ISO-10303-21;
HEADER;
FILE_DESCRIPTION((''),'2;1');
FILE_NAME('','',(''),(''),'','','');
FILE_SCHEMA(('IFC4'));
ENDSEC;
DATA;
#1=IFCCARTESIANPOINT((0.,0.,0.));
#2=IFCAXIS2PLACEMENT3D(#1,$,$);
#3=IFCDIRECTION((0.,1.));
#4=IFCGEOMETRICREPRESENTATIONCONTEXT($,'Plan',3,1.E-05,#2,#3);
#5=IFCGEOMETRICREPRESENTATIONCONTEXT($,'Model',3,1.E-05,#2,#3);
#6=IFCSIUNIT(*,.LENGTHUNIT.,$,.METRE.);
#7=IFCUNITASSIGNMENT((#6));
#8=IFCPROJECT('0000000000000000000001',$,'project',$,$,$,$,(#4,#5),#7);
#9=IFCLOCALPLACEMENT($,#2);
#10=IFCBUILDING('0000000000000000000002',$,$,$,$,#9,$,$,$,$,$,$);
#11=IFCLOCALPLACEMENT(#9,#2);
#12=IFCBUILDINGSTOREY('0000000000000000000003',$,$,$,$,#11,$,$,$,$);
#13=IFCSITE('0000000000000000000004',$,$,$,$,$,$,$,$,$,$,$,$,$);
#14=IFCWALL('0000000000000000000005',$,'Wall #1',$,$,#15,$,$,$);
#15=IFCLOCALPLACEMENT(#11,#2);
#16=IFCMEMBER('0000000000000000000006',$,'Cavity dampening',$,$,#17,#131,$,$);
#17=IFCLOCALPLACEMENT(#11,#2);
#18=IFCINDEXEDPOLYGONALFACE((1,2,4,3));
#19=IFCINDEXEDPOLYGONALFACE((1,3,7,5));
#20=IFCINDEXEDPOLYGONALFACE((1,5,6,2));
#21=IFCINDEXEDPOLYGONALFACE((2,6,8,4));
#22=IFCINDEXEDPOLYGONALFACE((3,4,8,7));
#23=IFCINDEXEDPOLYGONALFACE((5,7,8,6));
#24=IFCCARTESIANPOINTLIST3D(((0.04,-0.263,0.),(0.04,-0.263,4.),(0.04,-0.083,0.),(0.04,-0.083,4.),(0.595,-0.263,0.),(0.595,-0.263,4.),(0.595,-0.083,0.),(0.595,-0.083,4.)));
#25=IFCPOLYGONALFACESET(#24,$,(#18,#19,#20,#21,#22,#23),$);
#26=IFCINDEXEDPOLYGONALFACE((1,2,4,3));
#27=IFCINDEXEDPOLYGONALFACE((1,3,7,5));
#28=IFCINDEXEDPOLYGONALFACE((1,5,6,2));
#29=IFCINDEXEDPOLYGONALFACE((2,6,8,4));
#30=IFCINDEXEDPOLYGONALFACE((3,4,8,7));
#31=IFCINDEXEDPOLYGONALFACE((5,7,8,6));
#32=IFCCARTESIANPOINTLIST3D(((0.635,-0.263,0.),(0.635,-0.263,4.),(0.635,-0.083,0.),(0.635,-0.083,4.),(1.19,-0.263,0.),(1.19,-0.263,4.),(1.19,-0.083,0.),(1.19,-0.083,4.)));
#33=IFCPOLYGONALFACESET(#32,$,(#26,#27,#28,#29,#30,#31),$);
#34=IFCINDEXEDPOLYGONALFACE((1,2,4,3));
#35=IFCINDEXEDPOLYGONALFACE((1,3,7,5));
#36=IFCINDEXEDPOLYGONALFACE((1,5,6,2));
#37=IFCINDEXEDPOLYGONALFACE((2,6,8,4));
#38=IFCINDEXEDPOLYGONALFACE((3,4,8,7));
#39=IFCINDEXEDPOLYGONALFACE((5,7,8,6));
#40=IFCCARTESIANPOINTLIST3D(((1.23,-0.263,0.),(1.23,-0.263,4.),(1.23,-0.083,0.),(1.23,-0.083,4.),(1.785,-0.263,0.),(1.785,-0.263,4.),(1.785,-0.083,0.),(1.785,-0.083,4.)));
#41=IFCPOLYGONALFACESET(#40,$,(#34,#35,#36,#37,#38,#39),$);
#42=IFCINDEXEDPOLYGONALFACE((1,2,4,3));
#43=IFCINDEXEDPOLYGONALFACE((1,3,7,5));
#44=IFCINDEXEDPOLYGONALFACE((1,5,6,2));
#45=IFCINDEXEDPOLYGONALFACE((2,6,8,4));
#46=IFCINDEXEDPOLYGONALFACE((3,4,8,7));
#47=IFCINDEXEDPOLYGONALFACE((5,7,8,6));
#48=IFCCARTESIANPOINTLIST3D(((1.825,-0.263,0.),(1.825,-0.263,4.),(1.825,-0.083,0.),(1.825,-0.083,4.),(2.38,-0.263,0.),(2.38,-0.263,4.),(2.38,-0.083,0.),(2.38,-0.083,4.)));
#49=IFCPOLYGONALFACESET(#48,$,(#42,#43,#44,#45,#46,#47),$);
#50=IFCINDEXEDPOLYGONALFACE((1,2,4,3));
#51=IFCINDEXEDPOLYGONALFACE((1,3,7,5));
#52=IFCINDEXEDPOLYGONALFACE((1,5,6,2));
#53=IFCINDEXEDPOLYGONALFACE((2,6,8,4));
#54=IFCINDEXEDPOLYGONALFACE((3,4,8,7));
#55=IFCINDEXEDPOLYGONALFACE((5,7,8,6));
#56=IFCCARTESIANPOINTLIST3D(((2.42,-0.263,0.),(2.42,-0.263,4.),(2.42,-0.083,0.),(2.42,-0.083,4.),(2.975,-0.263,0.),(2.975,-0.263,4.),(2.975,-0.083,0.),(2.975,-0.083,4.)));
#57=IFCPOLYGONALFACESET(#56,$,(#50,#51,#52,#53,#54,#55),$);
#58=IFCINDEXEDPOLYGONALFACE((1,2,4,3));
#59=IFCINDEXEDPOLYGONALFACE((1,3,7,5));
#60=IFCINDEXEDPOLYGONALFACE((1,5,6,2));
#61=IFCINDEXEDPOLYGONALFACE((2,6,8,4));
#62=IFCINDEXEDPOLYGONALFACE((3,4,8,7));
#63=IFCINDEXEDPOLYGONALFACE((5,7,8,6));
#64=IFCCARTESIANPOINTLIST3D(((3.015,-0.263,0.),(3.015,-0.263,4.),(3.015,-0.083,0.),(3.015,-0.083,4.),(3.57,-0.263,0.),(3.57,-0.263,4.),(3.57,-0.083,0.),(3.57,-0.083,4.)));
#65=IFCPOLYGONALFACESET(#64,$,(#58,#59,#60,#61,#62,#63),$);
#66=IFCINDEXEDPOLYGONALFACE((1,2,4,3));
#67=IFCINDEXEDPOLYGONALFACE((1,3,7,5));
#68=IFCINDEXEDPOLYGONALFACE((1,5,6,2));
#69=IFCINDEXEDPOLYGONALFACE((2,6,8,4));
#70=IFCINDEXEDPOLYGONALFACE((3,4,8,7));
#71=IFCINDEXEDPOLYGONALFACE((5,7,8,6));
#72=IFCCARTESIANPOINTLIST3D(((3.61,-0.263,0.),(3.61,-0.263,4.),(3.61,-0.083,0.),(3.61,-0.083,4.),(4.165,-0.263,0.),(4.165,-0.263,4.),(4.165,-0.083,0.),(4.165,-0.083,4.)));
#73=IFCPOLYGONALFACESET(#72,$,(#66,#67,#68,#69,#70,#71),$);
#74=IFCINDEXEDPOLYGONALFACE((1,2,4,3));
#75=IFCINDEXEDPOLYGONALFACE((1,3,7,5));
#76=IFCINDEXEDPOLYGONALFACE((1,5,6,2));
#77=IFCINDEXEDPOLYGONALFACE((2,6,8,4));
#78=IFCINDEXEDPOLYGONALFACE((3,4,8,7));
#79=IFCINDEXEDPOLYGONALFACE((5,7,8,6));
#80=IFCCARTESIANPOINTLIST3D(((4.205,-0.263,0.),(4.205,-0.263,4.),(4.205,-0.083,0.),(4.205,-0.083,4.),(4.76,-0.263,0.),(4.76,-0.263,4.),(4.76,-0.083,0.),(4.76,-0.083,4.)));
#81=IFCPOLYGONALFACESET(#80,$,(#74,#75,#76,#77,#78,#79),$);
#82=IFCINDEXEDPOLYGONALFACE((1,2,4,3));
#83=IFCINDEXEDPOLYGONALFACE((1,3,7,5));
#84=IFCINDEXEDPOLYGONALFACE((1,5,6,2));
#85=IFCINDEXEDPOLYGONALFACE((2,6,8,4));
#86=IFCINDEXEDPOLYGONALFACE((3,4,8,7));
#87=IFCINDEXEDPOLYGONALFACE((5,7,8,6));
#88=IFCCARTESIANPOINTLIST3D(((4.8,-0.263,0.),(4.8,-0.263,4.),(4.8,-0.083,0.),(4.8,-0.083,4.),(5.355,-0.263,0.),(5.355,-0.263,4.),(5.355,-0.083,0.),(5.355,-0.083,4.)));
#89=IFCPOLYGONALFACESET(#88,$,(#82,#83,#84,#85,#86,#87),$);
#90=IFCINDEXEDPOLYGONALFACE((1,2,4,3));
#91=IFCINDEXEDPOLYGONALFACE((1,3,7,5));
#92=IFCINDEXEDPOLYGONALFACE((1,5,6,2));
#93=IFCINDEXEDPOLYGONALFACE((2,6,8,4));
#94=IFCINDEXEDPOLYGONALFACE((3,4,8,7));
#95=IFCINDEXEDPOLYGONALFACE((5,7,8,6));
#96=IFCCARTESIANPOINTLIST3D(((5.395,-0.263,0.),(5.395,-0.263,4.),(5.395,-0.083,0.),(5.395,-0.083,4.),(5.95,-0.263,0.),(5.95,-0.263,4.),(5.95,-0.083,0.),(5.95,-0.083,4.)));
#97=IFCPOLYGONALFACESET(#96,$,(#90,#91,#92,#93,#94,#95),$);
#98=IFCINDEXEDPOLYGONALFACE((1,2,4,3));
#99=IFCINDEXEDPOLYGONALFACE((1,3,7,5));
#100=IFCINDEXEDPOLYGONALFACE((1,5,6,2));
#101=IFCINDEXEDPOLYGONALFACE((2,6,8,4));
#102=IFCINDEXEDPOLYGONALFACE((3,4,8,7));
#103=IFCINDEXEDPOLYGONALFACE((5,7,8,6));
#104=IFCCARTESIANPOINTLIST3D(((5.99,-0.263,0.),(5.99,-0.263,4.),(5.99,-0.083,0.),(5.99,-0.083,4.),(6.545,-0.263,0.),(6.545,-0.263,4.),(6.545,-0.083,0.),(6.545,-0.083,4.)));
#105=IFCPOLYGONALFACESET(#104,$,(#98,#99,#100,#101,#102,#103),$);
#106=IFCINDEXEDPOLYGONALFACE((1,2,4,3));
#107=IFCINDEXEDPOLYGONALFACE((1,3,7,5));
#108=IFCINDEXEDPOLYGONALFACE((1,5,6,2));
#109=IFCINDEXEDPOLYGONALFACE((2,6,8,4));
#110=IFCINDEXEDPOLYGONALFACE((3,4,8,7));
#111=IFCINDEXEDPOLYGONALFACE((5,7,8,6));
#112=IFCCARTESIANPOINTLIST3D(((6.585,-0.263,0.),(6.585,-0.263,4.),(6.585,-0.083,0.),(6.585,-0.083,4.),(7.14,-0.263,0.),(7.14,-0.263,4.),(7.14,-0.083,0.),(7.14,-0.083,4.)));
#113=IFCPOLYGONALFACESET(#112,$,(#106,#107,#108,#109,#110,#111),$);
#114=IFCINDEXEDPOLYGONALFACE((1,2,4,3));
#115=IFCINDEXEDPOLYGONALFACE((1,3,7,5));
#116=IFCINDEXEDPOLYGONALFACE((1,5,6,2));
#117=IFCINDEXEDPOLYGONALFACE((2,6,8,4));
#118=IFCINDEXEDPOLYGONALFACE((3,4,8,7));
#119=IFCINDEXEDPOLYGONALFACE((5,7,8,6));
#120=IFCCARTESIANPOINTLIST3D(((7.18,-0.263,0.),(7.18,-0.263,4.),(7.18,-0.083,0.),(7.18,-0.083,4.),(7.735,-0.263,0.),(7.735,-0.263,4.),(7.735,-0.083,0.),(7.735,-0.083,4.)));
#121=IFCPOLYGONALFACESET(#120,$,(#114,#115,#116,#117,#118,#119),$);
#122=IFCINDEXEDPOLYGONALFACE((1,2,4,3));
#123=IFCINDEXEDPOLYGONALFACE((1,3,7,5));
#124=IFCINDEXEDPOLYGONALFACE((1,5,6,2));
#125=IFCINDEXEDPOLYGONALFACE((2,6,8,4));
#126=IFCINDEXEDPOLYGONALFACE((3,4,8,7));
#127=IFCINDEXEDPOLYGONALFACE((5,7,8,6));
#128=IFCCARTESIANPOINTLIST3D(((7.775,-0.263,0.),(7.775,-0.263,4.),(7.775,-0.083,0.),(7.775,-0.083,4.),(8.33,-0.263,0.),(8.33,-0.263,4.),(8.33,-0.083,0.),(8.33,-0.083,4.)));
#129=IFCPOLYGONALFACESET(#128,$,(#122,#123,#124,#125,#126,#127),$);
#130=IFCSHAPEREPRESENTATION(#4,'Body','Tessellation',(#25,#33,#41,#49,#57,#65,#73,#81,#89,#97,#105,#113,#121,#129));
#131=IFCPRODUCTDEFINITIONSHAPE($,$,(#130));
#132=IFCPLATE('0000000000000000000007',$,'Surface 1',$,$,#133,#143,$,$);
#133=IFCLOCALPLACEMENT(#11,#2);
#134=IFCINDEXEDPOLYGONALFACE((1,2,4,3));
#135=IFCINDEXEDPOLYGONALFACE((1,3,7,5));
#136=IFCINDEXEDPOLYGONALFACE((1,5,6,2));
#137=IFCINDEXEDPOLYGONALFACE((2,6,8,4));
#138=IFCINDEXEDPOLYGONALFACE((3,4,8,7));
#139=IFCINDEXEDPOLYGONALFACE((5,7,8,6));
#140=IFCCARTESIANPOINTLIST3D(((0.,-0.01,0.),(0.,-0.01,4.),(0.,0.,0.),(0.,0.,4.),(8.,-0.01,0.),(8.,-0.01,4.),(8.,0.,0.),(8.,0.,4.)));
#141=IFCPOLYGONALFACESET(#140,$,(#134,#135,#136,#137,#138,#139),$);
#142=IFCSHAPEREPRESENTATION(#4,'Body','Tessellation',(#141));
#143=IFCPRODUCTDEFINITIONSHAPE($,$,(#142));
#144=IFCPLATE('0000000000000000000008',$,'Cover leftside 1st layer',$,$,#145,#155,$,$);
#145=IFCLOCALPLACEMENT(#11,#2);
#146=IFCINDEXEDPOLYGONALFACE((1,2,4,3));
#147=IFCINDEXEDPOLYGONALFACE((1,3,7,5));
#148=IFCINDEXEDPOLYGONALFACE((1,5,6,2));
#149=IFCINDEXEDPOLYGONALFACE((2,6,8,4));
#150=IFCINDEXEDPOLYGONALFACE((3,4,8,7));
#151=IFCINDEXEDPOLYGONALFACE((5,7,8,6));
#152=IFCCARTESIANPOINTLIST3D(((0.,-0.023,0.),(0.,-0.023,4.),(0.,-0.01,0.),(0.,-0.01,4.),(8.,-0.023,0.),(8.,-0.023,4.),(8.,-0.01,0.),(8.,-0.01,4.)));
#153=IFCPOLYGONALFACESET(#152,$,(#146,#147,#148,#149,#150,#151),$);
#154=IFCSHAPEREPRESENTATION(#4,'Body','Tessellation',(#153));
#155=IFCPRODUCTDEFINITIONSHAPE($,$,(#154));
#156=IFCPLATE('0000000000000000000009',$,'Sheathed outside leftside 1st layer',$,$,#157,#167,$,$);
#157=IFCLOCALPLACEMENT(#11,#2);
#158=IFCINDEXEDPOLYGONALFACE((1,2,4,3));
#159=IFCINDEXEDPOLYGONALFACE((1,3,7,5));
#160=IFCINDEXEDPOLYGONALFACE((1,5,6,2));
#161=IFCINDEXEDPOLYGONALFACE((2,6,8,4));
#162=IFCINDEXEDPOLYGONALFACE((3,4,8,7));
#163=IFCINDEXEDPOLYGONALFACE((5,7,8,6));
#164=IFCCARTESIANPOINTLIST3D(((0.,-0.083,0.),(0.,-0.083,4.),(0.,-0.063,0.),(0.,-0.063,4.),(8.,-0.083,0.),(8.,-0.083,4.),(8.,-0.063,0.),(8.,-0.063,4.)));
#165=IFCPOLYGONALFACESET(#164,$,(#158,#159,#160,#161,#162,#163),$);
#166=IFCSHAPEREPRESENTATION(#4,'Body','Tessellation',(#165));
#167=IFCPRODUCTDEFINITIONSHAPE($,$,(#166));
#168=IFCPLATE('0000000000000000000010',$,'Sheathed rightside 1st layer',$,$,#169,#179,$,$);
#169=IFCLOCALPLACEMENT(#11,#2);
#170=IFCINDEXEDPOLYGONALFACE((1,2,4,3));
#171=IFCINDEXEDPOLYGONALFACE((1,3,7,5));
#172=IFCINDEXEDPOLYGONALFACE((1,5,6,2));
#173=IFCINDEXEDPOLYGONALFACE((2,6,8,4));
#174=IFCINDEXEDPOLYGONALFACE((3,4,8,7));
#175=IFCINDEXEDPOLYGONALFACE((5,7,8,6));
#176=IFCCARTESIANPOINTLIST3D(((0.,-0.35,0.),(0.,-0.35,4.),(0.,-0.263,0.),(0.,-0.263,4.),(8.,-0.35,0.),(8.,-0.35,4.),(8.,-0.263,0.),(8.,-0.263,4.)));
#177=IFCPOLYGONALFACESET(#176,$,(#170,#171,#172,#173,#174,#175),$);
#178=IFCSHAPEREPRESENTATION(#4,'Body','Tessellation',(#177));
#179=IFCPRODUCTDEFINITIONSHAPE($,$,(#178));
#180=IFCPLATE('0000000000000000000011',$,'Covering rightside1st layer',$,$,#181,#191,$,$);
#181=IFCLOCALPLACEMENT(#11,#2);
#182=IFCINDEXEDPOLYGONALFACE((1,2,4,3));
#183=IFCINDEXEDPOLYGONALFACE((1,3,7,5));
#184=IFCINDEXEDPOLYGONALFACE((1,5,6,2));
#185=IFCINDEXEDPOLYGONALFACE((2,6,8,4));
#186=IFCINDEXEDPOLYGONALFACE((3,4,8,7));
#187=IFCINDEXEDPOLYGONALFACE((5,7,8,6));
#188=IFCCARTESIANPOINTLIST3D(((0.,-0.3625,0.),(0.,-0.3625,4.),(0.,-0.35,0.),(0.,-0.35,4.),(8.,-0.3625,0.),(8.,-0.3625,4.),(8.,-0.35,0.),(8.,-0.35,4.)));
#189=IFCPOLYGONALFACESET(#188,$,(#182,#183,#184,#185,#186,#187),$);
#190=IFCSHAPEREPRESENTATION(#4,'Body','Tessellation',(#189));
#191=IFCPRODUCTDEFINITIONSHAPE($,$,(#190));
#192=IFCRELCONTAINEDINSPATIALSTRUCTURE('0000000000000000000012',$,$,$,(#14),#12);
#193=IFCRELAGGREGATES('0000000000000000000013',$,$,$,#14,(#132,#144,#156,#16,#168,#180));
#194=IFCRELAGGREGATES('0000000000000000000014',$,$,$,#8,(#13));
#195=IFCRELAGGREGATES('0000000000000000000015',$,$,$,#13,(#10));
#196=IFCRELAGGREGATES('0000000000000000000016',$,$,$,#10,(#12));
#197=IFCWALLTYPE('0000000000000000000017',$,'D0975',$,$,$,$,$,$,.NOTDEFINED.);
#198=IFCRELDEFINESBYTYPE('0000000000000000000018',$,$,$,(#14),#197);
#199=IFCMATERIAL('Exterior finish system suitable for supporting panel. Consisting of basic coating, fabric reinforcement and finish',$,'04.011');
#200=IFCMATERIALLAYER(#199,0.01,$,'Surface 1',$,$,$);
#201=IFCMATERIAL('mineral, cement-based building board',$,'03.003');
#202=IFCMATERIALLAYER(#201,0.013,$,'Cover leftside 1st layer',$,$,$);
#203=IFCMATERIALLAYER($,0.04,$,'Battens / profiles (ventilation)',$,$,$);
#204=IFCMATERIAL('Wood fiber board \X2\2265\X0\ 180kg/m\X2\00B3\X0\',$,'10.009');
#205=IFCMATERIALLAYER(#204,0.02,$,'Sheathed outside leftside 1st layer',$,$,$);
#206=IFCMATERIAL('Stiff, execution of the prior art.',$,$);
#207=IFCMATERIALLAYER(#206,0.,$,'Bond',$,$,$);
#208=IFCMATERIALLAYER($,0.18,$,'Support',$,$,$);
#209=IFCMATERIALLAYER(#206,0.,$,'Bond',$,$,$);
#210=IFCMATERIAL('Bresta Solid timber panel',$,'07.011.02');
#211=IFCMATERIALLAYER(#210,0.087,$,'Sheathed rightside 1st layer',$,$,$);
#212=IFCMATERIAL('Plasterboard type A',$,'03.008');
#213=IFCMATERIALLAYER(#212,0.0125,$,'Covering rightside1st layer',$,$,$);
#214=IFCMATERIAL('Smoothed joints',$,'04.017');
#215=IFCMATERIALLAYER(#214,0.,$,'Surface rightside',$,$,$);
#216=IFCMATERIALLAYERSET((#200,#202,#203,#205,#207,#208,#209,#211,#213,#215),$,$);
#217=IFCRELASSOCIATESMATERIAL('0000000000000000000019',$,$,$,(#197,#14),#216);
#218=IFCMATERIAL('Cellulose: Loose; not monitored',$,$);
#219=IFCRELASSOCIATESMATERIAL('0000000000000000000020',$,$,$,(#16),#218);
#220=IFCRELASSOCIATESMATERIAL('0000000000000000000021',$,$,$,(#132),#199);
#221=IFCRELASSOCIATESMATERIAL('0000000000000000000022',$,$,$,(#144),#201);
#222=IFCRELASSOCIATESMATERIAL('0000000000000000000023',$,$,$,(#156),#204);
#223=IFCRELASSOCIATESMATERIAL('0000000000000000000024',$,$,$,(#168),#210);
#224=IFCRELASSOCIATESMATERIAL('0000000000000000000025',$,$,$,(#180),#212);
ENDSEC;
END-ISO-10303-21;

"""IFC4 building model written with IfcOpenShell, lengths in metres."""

from ifc_helpers import new_model, si_unit, direction, frame, frame_2d, origin, origin_with_axes, place, context, project, spatial, rectangle, extrude, material, layer, layer_set, type_object, element, aggregate, save


model = new_model("IFC4")

# Units and contexts
plan_context = context("Plan", 3, precision=1e-05, world=origin(), true_north=direction((0.0, 1.0)))
model_context = context("Model", 3, precision=1e-05, world=origin(), true_north=direction((0.0, 1.0)))
ifc_project = project(units=[si_unit("LENGTHUNIT", "METRE")], contexts=[plan_context, model_context])

# Site, building, storey
site = spatial("IfcSite", under=ifc_project)
building_placement = place(None, origin())
building = spatial("IfcBuilding", under=site, at=building_placement)
storey_placement = place(building_placement, origin())
storey = spatial("IfcBuildingStorey", under=building, at=storey_placement)

# Wall, member, plates
ifc_material_1 = material(Name="Exterior finish system suitable for supporting panel. Consisting of basic coating, fabric reinforcement and finish", Category="04.011")
ifc_layer_1 = layer(ifc_material_1, 0.01, Name="Surface 1")
ifc_material_2 = material(Name="mineral, cement-based building board", Category="03.003")
ifc_layer_2 = layer(ifc_material_2, 0.013, Name="Cover leftside 1st layer")
ifc_layer_3 = layer(None, 0.04, Name="Battens / profiles (ventilation)")
ifc_material_3 = material(Name="Wood fiber board ≥ 180kg/m³", Category="10.009")
ifc_layer_4 = layer(ifc_material_3, 0.02, Name="Sheathed outside leftside 1st layer")
ifc_material_4 = material(Name="Stiff, execution of the prior art.")
ifc_layer_5 = layer(ifc_material_4, 0.0, Name="Bond")
ifc_layer_6 = layer(None, 0.18, Name="Support")
ifc_layer_7 = layer(ifc_material_4, 0.0, Name="Bond")
ifc_material_5 = material(Name="Bresta Solid timber panel", Category="07.011.02")
ifc_layer_8 = layer(ifc_material_5, 0.087, Name="Sheathed rightside 1st layer")
ifc_material_6 = material(Name="Plasterboard type A", Category="03.008")
ifc_layer_9 = layer(ifc_material_6, 0.0125, Name="Covering rightside1st layer")
ifc_material_7 = material(Name="Smoothed joints", Category="04.017")
ifc_layer_10 = layer(ifc_material_7, 0.0, Name="Surface rightside")
ifc_layer_set = layer_set([ifc_layer_1, ifc_layer_2, ifc_layer_3, ifc_layer_4, ifc_layer_5, ifc_layer_6, ifc_layer_7, ifc_layer_8, ifc_layer_9, ifc_layer_10])
wall_type = type_object("IfcWallType", Name="D0975", PredefinedType="NOTDEFINED", material=ifc_layer_set)
wall_placement = place(None, frame((0.0, 0.0, 0.0), z_axis=(0.0, -1.0, 0.0), x_axis=(1.0, 0.0, 0.0)))
wall = element("IfcWall", 1, at=wall_placement, inside=storey, type_object=wall_type, material=ifc_layer_set, Name="Wall #1")
ifc_material_8 = material(Name="Cellulose: Loose; not monitored")
member_1_placement = place(wall_placement, origin())
member_1 = element("IfcMember", 2, at=member_1_placement, material=ifc_material_8, Name="Cavity dampening", context=plan_context, shape_type="SweptSolid", body=[
    extrude(rectangle(XDim=0.555, YDim=0.18, at=frame_2d((0.2775, 0.09), x_axis=(1.0, 0.0))), frame((0.04, 4.0, 0.083), z_axis=(0.0, -1.0, 0.0), x_axis=(1.0, 0.0, 0.0)), (0.0, 0.0, 1.0), 4.0),
    extrude(rectangle(XDim=0.555, YDim=0.18, at=frame_2d((0.2775, 0.09), x_axis=(1.0, 0.0))), frame((0.635, 4.0, 0.083), z_axis=(0.0, -1.0, 0.0), x_axis=(1.0, 0.0, 0.0)), (0.0, 0.0, 1.0), 4.0),
    extrude(rectangle(XDim=0.555, YDim=0.18, at=frame_2d((0.2775, 0.09), x_axis=(1.0, 0.0))), frame((1.23, 4.0, 0.083), z_axis=(0.0, -1.0, 0.0), x_axis=(1.0, 0.0, 0.0)), (0.0, 0.0, 1.0), 4.0),
    extrude(rectangle(XDim=0.555, YDim=0.18, at=frame_2d((0.2775, 0.09), x_axis=(1.0, 0.0))), frame((1.825, 4.0, 0.083), z_axis=(0.0, -1.0, 0.0), x_axis=(1.0, 0.0, 0.0)), (0.0, 0.0, 1.0), 4.0),
    extrude(rectangle(XDim=0.555, YDim=0.18, at=frame_2d((0.2775, 0.09), x_axis=(1.0, 0.0))), frame((2.42, 4.0, 0.083), z_axis=(0.0, -1.0, 0.0), x_axis=(1.0, 0.0, 0.0)), (0.0, 0.0, 1.0), 4.0),
    extrude(rectangle(XDim=0.555, YDim=0.18, at=frame_2d((0.2775, 0.09), x_axis=(1.0, 0.0))), frame((3.015, 4.0, 0.083), z_axis=(0.0, -1.0, 0.0), x_axis=(1.0, 0.0, 0.0)), (0.0, 0.0, 1.0), 4.0),
    extrude(rectangle(XDim=0.555, YDim=0.18, at=frame_2d((0.2775, 0.09), x_axis=(1.0, 0.0))), frame((3.61, 4.0, 0.083), z_axis=(0.0, -1.0, 0.0), x_axis=(1.0, 0.0, 0.0)), (0.0, 0.0, 1.0), 4.0),
    extrude(rectangle(XDim=0.555, YDim=0.18, at=frame_2d((0.2775, 0.09), x_axis=(1.0, 0.0))), frame((4.205, 4.0, 0.083), z_axis=(0.0, -1.0, 0.0), x_axis=(1.0, 0.0, 0.0)), (0.0, 0.0, 1.0), 4.0),
    extrude(rectangle(XDim=0.555, YDim=0.18, at=frame_2d((0.2775, 0.09), x_axis=(1.0, 0.0))), frame((4.8, 4.0, 0.083), z_axis=(0.0, -1.0, 0.0), x_axis=(1.0, 0.0, 0.0)), (0.0, 0.0, 1.0), 4.0),
    extrude(rectangle(XDim=0.555, YDim=0.18, at=frame_2d((0.2775, 0.09), x_axis=(1.0, 0.0))), frame((5.395, 4.0, 0.083), z_axis=(0.0, -1.0, 0.0), x_axis=(1.0, 0.0, 0.0)), (0.0, 0.0, 1.0), 4.0),
    extrude(rectangle(XDim=0.555, YDim=0.18, at=frame_2d((0.2775, 0.09), x_axis=(1.0, 0.0))), frame((5.99, 4.0, 0.083), z_axis=(0.0, -1.0, 0.0), x_axis=(1.0, 0.0, 0.0)), (0.0, 0.0, 1.0), 4.0),
    extrude(rectangle(XDim=0.555, YDim=0.18, at=frame_2d((0.2775, 0.09), x_axis=(1.0, 0.0))), frame((6.585, 4.0, 0.083), z_axis=(0.0, -1.0, 0.0), x_axis=(1.0, 0.0, 0.0)), (0.0, 0.0, 1.0), 4.0),
    extrude(rectangle(XDim=0.555, YDim=0.18, at=frame_2d((0.2775, 0.09), x_axis=(1.0, 0.0))), frame((7.18, 4.0, 0.083), z_axis=(0.0, -1.0, 0.0), x_axis=(1.0, 0.0, 0.0)), (0.0, 0.0, 1.0), 4.0),
    extrude(rectangle(XDim=0.555, YDim=0.18, at=frame_2d((0.2775, 0.09), x_axis=(1.0, 0.0))), frame((7.775, 4.0, 0.083), z_axis=(0.0, -1.0, 0.0), x_axis=(1.0, 0.0, 0.0)), (0.0, 0.0, 1.0), 4.0),
])
plate_1_placement = place(wall_placement, origin())
plate_1 = element("IfcPlate", 3, at=plate_1_placement, material=ifc_material_1, Name="Surface 1", context=plan_context, shape_type="SweptSolid", body=[
    extrude(rectangle(XDim=8.0, YDim=4.0, at=frame_2d((4.0, 2.0), x_axis=(1.0, 0.0))), origin_with_axes(), (0.0, 0.0, 1.0), 0.01),
])
plate_2_placement = place(wall_placement, origin())
plate_2 = element("IfcPlate", 4, at=plate_2_placement, material=ifc_material_2, Name="Cover leftside 1st layer", context=plan_context, shape_type="SweptSolid", body=[
    extrude(rectangle(XDim=8.0, YDim=4.0, at=frame_2d((4.0, 2.0), x_axis=(1.0, 0.0))), frame((0.0, 0.0, 0.01), z_axis=(0.0, 0.0, 1.0), x_axis=(1.0, 0.0, 0.0)), (0.0, 0.0, 1.0), 0.013),
])
plate_3_placement = place(wall_placement, origin())
plate_3 = element("IfcPlate", 5, at=plate_3_placement, material=ifc_material_3, Name="Sheathed outside leftside 1st layer", context=plan_context, shape_type="SweptSolid", body=[
    extrude(rectangle(XDim=8.0, YDim=4.0, at=frame_2d((4.0, 2.0), x_axis=(1.0, 0.0))), frame((0.0, 0.0, 0.063), z_axis=(0.0, 0.0, 1.0), x_axis=(1.0, 0.0, 0.0)), (0.0, 0.0, 1.0), 0.02),
])
plate_4_placement = place(wall_placement, origin())
plate_4 = element("IfcPlate", 6, at=plate_4_placement, material=ifc_material_5, Name="Sheathed rightside 1st layer", context=plan_context, shape_type="SweptSolid", body=[
    extrude(rectangle(XDim=8.0, YDim=4.0, at=frame_2d((4.0, 2.0), x_axis=(1.0, 0.0))), frame((0.0, 0.0, 0.263), z_axis=(0.0, 0.0, 1.0), x_axis=(1.0, 0.0, 0.0)), (0.0, 0.0, 1.0), 0.087),
])
plate_5_placement = place(wall_placement, origin())
plate_5 = element("IfcPlate", 7, at=plate_5_placement, material=ifc_material_6, Name="Covering rightside1st layer", context=plan_context, shape_type="SweptSolid", body=[
    extrude(rectangle(XDim=8.0, YDim=4.0, at=frame_2d((4.0, 2.0), x_axis=(1.0, 0.0))), frame((0.0, 0.0, 0.35), z_axis=(0.0, 0.0, 1.0), x_axis=(1.0, 0.0, 0.0)), (0.0, 0.0, 1.0), 0.0125),
])
aggregate(wall, [plate_1, plate_2, plate_3, member_1, plate_4, plate_5])

save(model, "model.ifc")
